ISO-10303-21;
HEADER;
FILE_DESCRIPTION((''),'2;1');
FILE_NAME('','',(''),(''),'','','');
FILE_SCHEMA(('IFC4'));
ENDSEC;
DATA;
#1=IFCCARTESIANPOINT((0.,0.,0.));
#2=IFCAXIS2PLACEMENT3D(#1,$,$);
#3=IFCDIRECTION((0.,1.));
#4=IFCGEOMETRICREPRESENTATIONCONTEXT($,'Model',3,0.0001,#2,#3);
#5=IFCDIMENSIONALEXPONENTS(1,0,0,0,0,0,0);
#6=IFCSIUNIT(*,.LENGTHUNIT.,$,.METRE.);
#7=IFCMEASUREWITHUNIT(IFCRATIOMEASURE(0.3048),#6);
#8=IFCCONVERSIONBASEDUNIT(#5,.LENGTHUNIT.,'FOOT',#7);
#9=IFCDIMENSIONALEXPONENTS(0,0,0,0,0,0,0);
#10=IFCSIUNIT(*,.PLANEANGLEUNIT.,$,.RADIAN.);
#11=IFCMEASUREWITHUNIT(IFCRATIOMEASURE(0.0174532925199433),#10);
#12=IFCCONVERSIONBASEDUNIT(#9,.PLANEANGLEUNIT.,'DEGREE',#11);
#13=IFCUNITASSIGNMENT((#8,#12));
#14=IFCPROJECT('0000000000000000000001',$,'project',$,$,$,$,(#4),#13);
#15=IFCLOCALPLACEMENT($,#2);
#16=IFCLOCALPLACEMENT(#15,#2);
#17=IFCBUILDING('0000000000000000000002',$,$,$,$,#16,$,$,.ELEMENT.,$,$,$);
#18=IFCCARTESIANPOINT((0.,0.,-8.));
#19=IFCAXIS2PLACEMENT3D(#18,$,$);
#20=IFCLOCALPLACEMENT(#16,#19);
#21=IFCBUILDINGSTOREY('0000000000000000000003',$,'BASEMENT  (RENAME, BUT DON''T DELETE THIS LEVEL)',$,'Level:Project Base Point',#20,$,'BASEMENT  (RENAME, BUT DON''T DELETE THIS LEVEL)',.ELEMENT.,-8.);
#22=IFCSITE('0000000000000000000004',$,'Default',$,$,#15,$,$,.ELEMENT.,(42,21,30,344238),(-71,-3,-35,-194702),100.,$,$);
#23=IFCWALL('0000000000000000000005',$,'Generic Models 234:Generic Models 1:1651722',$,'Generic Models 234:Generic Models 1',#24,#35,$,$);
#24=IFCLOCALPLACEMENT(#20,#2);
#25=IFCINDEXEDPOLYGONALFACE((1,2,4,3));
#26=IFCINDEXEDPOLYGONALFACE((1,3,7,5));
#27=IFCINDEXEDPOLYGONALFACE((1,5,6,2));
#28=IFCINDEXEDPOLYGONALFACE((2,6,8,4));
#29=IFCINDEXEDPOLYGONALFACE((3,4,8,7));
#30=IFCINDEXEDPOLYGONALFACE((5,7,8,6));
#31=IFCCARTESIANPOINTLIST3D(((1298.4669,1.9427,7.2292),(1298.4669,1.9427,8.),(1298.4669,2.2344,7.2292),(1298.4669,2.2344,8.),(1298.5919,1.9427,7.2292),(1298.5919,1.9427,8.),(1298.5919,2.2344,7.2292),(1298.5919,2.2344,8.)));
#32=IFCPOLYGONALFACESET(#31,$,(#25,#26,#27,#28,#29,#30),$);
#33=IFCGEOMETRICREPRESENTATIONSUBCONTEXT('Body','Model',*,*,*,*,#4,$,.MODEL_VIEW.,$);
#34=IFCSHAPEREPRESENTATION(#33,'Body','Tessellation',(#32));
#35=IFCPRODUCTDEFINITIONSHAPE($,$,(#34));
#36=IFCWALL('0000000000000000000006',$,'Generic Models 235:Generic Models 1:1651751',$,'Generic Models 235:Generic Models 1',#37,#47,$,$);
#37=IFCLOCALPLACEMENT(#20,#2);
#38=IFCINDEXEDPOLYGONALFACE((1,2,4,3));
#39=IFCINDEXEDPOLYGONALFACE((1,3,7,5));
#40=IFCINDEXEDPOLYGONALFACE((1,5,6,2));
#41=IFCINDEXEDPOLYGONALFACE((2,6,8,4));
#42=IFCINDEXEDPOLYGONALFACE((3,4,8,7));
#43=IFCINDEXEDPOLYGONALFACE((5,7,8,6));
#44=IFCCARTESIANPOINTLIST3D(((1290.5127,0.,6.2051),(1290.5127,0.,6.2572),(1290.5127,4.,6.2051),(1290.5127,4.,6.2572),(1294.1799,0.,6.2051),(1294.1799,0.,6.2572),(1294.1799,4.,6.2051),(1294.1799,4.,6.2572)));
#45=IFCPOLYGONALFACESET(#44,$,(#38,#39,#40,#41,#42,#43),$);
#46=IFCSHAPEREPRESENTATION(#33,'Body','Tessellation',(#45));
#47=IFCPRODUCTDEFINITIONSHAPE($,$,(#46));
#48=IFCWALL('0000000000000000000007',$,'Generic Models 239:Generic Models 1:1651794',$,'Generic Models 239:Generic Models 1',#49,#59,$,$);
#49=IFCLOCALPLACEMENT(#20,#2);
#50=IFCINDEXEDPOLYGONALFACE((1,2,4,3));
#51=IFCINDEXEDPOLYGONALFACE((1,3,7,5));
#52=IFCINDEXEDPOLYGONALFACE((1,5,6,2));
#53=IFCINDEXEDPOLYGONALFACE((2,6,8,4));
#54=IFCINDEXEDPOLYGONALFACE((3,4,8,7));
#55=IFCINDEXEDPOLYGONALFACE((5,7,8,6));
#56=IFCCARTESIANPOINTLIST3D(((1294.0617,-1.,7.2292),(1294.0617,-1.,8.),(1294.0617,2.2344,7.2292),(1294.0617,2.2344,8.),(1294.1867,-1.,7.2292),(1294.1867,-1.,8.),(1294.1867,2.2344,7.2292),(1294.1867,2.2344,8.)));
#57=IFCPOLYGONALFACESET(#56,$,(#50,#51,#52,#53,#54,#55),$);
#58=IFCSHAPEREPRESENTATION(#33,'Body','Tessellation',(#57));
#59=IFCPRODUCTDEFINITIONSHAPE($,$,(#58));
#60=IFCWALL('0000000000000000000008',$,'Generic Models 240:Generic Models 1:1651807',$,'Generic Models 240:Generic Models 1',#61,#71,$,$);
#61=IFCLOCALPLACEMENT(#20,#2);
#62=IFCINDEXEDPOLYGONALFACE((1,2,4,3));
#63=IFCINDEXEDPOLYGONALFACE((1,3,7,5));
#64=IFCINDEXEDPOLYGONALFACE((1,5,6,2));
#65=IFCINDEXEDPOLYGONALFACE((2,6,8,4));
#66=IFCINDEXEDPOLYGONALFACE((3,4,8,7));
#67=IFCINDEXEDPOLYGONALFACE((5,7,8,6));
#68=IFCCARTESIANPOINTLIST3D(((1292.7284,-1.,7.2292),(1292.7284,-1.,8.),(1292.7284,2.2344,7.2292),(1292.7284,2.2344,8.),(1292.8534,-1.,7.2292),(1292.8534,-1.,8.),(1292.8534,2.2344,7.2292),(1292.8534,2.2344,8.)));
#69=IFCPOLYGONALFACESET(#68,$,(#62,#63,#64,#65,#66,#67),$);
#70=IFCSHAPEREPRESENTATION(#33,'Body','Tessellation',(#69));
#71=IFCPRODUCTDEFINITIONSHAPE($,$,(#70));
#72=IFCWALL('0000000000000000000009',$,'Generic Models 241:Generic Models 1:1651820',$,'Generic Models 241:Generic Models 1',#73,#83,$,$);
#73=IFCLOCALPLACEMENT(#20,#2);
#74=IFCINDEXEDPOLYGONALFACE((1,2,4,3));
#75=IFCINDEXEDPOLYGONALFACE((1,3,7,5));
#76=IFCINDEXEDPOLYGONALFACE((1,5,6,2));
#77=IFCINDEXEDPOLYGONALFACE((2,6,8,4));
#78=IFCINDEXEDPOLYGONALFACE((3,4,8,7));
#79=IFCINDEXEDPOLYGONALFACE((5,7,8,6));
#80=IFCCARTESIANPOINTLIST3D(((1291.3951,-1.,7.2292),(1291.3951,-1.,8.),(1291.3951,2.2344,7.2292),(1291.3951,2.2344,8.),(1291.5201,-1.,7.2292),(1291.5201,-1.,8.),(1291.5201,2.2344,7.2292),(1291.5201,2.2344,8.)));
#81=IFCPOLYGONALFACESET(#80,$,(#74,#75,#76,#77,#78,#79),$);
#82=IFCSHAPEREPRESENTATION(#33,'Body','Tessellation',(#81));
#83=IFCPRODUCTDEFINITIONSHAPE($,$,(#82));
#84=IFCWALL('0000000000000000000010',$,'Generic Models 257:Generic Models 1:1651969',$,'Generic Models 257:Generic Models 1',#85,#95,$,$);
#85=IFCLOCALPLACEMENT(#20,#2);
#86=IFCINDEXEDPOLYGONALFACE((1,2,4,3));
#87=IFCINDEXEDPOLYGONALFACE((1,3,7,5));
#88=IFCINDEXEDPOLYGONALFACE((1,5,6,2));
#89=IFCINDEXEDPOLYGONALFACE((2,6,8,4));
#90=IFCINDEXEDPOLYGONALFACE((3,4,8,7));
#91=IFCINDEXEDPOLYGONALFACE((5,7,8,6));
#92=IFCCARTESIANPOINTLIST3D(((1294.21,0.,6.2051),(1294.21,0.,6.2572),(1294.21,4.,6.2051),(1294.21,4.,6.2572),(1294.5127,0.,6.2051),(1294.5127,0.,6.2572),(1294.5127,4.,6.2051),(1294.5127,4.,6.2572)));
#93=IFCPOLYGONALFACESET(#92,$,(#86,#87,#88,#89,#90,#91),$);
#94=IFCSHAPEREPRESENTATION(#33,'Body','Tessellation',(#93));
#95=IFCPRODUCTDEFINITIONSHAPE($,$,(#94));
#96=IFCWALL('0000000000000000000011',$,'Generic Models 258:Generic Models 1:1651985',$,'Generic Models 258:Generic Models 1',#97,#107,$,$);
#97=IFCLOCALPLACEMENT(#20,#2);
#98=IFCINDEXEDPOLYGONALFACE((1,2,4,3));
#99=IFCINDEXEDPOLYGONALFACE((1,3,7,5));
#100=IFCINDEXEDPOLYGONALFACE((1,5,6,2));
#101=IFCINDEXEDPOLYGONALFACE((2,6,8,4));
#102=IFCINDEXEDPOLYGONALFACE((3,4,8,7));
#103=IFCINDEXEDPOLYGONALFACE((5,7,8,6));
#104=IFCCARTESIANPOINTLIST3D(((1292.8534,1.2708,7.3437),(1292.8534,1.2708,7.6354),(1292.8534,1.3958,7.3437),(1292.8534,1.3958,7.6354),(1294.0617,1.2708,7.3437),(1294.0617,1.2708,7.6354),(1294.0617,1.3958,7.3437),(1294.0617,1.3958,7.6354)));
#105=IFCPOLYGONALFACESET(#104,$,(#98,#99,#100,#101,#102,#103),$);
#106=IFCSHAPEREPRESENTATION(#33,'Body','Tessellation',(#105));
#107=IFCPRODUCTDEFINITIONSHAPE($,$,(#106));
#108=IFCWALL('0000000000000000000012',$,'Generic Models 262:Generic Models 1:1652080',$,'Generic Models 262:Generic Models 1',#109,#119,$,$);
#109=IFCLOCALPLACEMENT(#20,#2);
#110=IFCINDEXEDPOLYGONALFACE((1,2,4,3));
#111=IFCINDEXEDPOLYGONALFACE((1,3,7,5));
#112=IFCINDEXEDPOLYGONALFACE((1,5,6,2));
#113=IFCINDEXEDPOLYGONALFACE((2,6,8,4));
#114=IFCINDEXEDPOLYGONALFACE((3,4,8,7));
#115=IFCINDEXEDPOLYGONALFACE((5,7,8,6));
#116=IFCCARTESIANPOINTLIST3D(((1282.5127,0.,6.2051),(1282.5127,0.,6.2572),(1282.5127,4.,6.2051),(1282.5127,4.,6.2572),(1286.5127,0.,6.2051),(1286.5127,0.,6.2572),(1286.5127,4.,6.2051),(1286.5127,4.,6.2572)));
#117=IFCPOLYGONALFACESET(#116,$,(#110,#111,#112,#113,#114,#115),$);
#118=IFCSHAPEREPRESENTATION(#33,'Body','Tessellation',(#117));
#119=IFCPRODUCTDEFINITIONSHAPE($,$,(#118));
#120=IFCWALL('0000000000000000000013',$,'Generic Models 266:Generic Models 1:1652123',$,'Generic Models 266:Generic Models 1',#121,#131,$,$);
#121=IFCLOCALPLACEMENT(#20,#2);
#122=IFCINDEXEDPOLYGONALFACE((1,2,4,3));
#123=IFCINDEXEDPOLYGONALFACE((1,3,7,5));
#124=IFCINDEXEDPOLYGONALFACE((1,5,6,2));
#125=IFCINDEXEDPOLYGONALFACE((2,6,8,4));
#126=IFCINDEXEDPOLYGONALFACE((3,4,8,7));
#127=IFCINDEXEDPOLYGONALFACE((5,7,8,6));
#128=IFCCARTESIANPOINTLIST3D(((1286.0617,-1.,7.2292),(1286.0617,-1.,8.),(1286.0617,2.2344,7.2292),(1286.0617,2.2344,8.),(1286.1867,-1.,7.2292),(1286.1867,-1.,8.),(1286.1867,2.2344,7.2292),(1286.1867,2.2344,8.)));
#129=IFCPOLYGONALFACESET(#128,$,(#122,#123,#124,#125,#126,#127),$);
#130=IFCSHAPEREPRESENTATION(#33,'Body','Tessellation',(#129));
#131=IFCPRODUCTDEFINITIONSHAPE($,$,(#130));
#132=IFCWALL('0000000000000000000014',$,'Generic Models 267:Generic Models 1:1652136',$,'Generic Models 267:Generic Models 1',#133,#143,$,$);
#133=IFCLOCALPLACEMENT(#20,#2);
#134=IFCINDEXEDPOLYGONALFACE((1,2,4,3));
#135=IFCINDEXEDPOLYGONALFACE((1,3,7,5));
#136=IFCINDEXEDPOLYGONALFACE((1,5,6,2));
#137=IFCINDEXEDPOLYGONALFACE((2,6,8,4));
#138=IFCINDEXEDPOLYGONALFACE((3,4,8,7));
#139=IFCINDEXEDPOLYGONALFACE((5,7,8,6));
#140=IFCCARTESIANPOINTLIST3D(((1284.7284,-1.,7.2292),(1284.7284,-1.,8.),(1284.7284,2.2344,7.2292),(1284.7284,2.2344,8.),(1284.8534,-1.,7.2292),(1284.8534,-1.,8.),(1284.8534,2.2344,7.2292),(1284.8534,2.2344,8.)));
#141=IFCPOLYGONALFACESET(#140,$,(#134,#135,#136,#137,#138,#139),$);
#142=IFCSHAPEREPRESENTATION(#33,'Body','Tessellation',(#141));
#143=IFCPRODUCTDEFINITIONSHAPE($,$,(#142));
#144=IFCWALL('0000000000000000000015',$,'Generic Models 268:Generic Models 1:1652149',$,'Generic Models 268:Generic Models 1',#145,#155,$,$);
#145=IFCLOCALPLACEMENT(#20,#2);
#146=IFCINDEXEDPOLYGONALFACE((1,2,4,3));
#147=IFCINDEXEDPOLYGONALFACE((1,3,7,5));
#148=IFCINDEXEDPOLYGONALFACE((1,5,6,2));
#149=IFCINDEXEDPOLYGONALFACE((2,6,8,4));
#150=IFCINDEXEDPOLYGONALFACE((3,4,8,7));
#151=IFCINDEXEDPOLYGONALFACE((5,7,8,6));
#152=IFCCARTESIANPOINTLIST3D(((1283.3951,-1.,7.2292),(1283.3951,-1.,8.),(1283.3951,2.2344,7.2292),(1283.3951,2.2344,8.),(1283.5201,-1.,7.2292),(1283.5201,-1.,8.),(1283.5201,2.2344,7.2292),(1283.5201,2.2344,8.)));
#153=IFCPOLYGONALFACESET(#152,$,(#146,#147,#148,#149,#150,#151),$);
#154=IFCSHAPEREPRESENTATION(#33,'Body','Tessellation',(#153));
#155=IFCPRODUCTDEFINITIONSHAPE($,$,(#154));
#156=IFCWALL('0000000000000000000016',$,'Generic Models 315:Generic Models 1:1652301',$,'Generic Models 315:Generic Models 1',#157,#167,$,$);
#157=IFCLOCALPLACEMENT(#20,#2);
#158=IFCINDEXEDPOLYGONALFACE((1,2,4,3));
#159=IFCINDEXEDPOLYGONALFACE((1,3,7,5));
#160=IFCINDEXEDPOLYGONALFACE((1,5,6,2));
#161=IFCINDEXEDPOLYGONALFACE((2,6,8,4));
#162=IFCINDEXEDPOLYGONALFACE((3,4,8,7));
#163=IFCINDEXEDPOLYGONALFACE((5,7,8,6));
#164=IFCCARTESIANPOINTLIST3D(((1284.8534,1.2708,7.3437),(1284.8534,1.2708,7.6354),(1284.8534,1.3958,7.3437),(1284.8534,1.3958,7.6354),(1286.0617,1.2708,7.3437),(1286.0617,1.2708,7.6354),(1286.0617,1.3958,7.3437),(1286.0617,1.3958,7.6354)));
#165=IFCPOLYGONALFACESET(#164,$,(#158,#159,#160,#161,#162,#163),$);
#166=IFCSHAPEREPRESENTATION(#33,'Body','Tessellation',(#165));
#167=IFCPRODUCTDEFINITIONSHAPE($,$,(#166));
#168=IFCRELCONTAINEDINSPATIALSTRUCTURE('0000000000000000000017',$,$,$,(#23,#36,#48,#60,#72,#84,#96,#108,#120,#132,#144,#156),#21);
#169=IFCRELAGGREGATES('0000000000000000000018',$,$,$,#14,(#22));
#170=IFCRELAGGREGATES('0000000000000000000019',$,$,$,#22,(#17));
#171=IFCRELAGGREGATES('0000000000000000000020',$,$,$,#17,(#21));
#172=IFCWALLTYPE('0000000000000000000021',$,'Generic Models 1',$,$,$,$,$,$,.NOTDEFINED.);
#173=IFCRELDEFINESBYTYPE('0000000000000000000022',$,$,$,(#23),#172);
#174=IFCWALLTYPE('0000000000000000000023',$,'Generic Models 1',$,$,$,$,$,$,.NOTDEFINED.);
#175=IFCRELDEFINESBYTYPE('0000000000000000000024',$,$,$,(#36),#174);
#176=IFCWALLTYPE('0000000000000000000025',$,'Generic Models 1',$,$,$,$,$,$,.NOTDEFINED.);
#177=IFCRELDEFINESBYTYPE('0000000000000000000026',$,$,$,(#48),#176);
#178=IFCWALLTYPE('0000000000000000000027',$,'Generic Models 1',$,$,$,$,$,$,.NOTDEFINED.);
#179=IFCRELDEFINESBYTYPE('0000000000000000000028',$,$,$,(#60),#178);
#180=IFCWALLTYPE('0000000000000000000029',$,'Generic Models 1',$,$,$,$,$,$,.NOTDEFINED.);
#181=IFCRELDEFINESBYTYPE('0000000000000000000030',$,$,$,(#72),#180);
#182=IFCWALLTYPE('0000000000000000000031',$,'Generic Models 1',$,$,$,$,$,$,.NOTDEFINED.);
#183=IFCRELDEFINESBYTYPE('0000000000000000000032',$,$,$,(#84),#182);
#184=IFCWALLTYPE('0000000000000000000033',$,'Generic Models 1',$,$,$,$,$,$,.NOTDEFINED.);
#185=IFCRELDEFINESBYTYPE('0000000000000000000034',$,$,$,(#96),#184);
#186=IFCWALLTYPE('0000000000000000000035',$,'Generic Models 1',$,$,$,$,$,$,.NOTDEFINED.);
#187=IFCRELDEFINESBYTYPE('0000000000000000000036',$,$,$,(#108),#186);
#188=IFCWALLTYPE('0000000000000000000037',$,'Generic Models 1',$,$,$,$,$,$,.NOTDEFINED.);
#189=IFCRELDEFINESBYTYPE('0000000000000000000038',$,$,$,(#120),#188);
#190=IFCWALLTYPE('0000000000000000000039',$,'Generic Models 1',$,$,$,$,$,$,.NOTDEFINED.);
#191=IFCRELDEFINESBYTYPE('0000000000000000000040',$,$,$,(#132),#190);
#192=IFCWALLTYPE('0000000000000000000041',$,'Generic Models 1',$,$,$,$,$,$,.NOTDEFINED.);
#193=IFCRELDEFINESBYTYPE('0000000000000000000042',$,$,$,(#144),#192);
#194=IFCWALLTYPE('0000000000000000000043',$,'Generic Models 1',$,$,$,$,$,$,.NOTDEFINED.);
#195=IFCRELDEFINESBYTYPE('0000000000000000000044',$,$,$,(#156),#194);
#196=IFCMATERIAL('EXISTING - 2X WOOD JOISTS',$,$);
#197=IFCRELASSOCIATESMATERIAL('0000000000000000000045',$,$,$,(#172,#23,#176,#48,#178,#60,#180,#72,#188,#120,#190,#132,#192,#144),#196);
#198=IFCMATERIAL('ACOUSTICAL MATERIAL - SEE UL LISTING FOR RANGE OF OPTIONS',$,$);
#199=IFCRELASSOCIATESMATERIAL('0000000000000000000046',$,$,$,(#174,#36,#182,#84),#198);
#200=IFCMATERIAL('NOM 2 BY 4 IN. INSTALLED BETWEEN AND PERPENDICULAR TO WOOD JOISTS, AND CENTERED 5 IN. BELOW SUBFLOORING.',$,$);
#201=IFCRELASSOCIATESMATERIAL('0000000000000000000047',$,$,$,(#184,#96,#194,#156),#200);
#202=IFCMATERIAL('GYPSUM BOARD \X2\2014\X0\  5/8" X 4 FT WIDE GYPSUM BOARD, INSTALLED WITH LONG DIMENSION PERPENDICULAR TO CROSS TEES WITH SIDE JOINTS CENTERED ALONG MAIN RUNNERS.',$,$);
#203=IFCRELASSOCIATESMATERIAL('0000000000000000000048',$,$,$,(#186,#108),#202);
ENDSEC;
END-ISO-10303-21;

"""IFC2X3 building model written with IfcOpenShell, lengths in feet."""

from ifc_helpers import new_model, entity, si_unit, converted_unit, direction, frame, frame_2d, origin, origin_2d_with_axis, place, context, subcontext, project, spatial, rectangle, extrude, material, type_object, element, save


model = new_model("IFC2X3")

# Units and contexts
model_context = context("Model", 3, precision=0.0001, world=origin(), true_north=direction((0.0, 1.0)))
body_context = subcontext(model_context, "Body", "Model", "MODEL_VIEW")
ifc_project = project(units=[converted_unit("LENGTHUNIT", "FOOT", entity("IfcRatioMeasure", 0.3048), si_unit("LENGTHUNIT", "METRE"), dimensions=[1, 0, 0, 0, 0, 0, 0]), converted_unit("PLANEANGLEUNIT", "DEGREE", entity("IfcRatioMeasure", 0.0174532925199433), si_unit("PLANEANGLEUNIT", "RADIAN"), dimensions=[0, 0, 0, 0, 0, 0, 0])], contexts=[model_context])

# Site, building, storey
site_placement = place(None, origin())
site = spatial("IfcSite", under=ifc_project, at=site_placement, Name="Default", CompositionType="ELEMENT", RefLatitude=(42, 21, 30, 344238), RefLongitude=(-71, -3, -35, -194702), RefElevation=100.0)
building_placement = place(site_placement, origin())
building = spatial("IfcBuilding", under=site, at=building_placement, CompositionType="ELEMENT")
storey_placement = place(building_placement, frame((0.0, 0.0, -8.0)))
storey = spatial("IfcBuildingStorey", under=building, at=storey_placement, Name="BASEMENT  (RENAME, BUT DON'T DELETE THIS LEVEL)", ObjectType="Level:Project Base Point", LongName="BASEMENT  (RENAME, BUT DON'T DELETE THIS LEVEL)", CompositionType="ELEMENT", Elevation=-8.0)

# Walls
ifc_material_1 = material(Name="EXISTING - 2X WOOD JOISTS")
wall_type_1 = type_object("IfcWallType", Name="Generic Models 1", PredefinedType="NOTDEFINED", material=ifc_material_1)
wall_1_placement = place(storey_placement, frame((1298.4669, 1.9427, 7.2292), z_axis=(0.0, 0.0, 1.0), x_axis=(0.0, 1.0, 0.0)))
element("IfcWall", 1, at=wall_1_placement, inside=storey, type_object=wall_type_1, material=ifc_material_1, Name="Generic Models 234:Generic Models 1:1651722", ObjectType="Generic Models 234:Generic Models 1", context=body_context, shape_type="SweptSolid", body=[
    extrude(rectangle(XDim=0.2917, YDim=0.125, at=frame_2d((0.0, 0.0), x_axis=(1.0, 0.0))), frame((0.1458, -0.0625, 0.0)), (0.0, 0.0, 1.0), 0.7708),
])
ifc_material_2 = material(Name="ACOUSTICAL MATERIAL - SEE UL LISTING FOR RANGE OF OPTIONS")
wall_type_2 = type_object("IfcWallType", Name="Generic Models 1", PredefinedType="NOTDEFINED", material=ifc_material_2)
wall_2_placement = place(storey_placement, frame((1290.5127, 0.0, 6.2051), z_axis=(0.0, 0.0, 1.0), x_axis=(0.0, 1.0, 0.0)))
element("IfcWall", 2, at=wall_2_placement, inside=storey, type_object=wall_type_2, material=ifc_material_2, Name="Generic Models 235:Generic Models 1:1651751", ObjectType="Generic Models 235:Generic Models 1", context=body_context, shape_type="SweptSolid", body=[
    extrude(rectangle(XDim=4.0, YDim=3.6671, at=frame_2d((0.0, 0.0), x_axis=(1.0, 0.0))), frame((2.0, -1.8336, 0.0)), (0.0, 0.0, 1.0), 0.0521),
])
wall_type_3 = type_object("IfcWallType", Name="Generic Models 1", PredefinedType="NOTDEFINED", material=ifc_material_1)
wall_3_placement = place(storey_placement, frame((1294.0617, -1.0, 7.2292), z_axis=(0.0, 0.0, 1.0), x_axis=(0.0, 1.0, 0.0)))
element("IfcWall", 3, at=wall_3_placement, inside=storey, type_object=wall_type_3, material=ifc_material_1, Name="Generic Models 239:Generic Models 1:1651794", ObjectType="Generic Models 239:Generic Models 1", context=body_context, shape_type="SweptSolid", body=[
    extrude(rectangle(XDim=3.2344, YDim=0.125, at=frame_2d((0.0, 0.0), x_axis=(1.0, 0.0))), frame((1.6172, -0.0625, 0.0)), (0.0, 0.0, 1.0), 0.7708),
])
wall_type_4 = type_object("IfcWallType", Name="Generic Models 1", PredefinedType="NOTDEFINED", material=ifc_material_1)
wall_4_placement = place(storey_placement, frame((1292.7284, -1.0, 7.2292), z_axis=(0.0, 0.0, 1.0), x_axis=(0.0, 1.0, 0.0)))
element("IfcWall", 4, at=wall_4_placement, inside=storey, type_object=wall_type_4, material=ifc_material_1, Name="Generic Models 240:Generic Models 1:1651807", ObjectType="Generic Models 240:Generic Models 1", context=body_context, shape_type="SweptSolid", body=[
    extrude(rectangle(XDim=3.2344, YDim=0.125, at=frame_2d((0.0, 0.0), x_axis=(1.0, 0.0))), frame((1.6172, -0.0625, 0.0)), (0.0, 0.0, 1.0), 0.7708),
])
wall_type_5 = type_object("IfcWallType", Name="Generic Models 1", PredefinedType="NOTDEFINED", material=ifc_material_1)
wall_5_placement = place(storey_placement, frame((1291.3951, -1.0, 7.2292), z_axis=(0.0, 0.0, 1.0), x_axis=(0.0, 1.0, 0.0)))
element("IfcWall", 5, at=wall_5_placement, inside=storey, type_object=wall_type_5, material=ifc_material_1, Name="Generic Models 241:Generic Models 1:1651820", ObjectType="Generic Models 241:Generic Models 1", context=body_context, shape_type="SweptSolid", body=[
    extrude(rectangle(XDim=3.2344, YDim=0.125, at=frame_2d((0.0, 0.0), x_axis=(1.0, 0.0))), frame((1.6172, -0.0625, 0.0)), (0.0, 0.0, 1.0), 0.7708),
])
wall_type_6 = type_object("IfcWallType", Name="Generic Models 1", PredefinedType="NOTDEFINED", material=ifc_material_2)
wall_6_placement = place(storey_placement, frame((1294.21, 0.0, 6.2051), z_axis=(0.0, 0.0, 1.0), x_axis=(0.0, 1.0, 0.0)))
element("IfcWall", 6, at=wall_6_placement, inside=storey, type_object=wall_type_6, material=ifc_material_2, Name="Generic Models 257:Generic Models 1:1651969", ObjectType="Generic Models 257:Generic Models 1", context=body_context, shape_type="SweptSolid", body=[
    extrude(rectangle(XDim=4.0, YDim=0.3027, at=frame_2d((0.0, 0.0), x_axis=(1.0, 0.0))), frame((2.0, -0.1514, 0.0)), (0.0, 0.0, 1.0), 0.0521),
])
ifc_material_3 = material(Name="NOM 2 BY 4 IN. INSTALLED BETWEEN AND PERPENDICULAR TO WOOD JOISTS, AND CENTERED 5 IN. BELOW SUBFLOORING.")
wall_type_7 = type_object("IfcWallType", Name="Generic Models 1", PredefinedType="NOTDEFINED", material=ifc_material_3)
wall_7_placement = place(storey_placement, frame((1292.8534, 1.2708, 7.3437)))
element("IfcWall", 7, at=wall_7_placement, inside=storey, type_object=wall_type_7, material=ifc_material_3, Name="Generic Models 258:Generic Models 1:1651985", ObjectType="Generic Models 258:Generic Models 1", context=body_context, shape_type="SweptSolid", body=[
    extrude(rectangle(XDim=0.125, YDim=1.2083, at=frame_2d((0.0, 0.0), x_axis=(1.0, 0.0))), frame((0.6042, 0.0625, 0.0), z_axis=(0.0, 0.0, 1.0), x_axis=(0.0, 1.0, 0.0)), (0.0, 0.0, 1.0), 0.2917),
])
ifc_material_4 = material(Name="GYPSUM BOARD —  5/8\" X 4 FT WIDE GYPSUM BOARD, INSTALLED WITH LONG DIMENSION PERPENDICULAR TO CROSS TEES WITH SIDE JOINTS CENTERED ALONG MAIN RUNNERS.")
wall_type_8 = type_object("IfcWallType", Name="Generic Models 1", PredefinedType="NOTDEFINED", material=ifc_material_4)
wall_8_placement = place(storey_placement, frame((1282.5127, 0.0, 6.2051), z_axis=(0.0, 0.0, 1.0), x_axis=(0.0, 1.0, 0.0)))
element("IfcWall", 8, at=wall_8_placement, inside=storey, type_object=wall_type_8, material=ifc_material_4, Name="Generic Models 262:Generic Models 1:1652080", ObjectType="Generic Models 262:Generic Models 1", context=body_context, shape_type="SweptSolid", body=[
    extrude(rectangle(XDim=4.0, YDim=4.0, at=origin_2d_with_axis()), frame((2.0, -2.0, 0.0)), (0.0, 0.0, 1.0), 0.0521),
])
wall_type_9 = type_object("IfcWallType", Name="Generic Models 1", PredefinedType="NOTDEFINED", material=ifc_material_1)
wall_9_placement = place(storey_placement, frame((1286.0617, -1.0, 7.2292), z_axis=(0.0, 0.0, 1.0), x_axis=(0.0, 1.0, 0.0)))
element("IfcWall", 9, at=wall_9_placement, inside=storey, type_object=wall_type_9, material=ifc_material_1, Name="Generic Models 266:Generic Models 1:1652123", ObjectType="Generic Models 266:Generic Models 1", context=body_context, shape_type="SweptSolid", body=[
    extrude(rectangle(XDim=3.2344, YDim=0.125, at=frame_2d((0.0, 0.0), x_axis=(1.0, 0.0))), frame((1.6172, -0.0625, 0.0)), (0.0, 0.0, 1.0), 0.7708),
])
wall_type_10 = type_object("IfcWallType", Name="Generic Models 1", PredefinedType="NOTDEFINED", material=ifc_material_1)
wall_10_placement = place(storey_placement, frame((1284.7284, -1.0, 7.2292), z_axis=(0.0, 0.0, 1.0), x_axis=(0.0, 1.0, 0.0)))
element("IfcWall", 10, at=wall_10_placement, inside=storey, type_object=wall_type_10, material=ifc_material_1, Name="Generic Models 267:Generic Models 1:1652136", ObjectType="Generic Models 267:Generic Models 1", context=body_context, shape_type="SweptSolid", body=[
    extrude(rectangle(XDim=3.2344, YDim=0.125, at=frame_2d((0.0, 0.0), x_axis=(1.0, 0.0))), frame((1.6172, -0.0625, 0.0)), (0.0, 0.0, 1.0), 0.7708),
])
wall_type_11 = type_object("IfcWallType", Name="Generic Models 1", PredefinedType="NOTDEFINED", material=ifc_material_1)
wall_11_placement = place(storey_placement, frame((1283.3951, -1.0, 7.2292), z_axis=(0.0, 0.0, 1.0), x_axis=(0.0, 1.0, 0.0)))
element("IfcWall", 11, at=wall_11_placement, inside=storey, type_object=wall_type_11, material=ifc_material_1, Name="Generic Models 268:Generic Models 1:1652149", ObjectType="Generic Models 268:Generic Models 1", context=body_context, shape_type="SweptSolid", body=[
    extrude(rectangle(XDim=3.2344, YDim=0.125, at=frame_2d((0.0, 0.0), x_axis=(1.0, 0.0))), frame((1.6172, -0.0625, 0.0)), (0.0, 0.0, 1.0), 0.7708),
])
wall_type_12 = type_object("IfcWallType", Name="Generic Models 1", PredefinedType="NOTDEFINED", material=ifc_material_3)
wall_12_placement = place(storey_placement, frame((1284.8534, 1.2708, 7.3437)))
element("IfcWall", 12, at=wall_12_placement, inside=storey, type_object=wall_type_12, material=ifc_material_3, Name="Generic Models 315:Generic Models 1:1652301", ObjectType="Generic Models 315:Generic Models 1", context=body_context, shape_type="SweptSolid", body=[
    extrude(rectangle(XDim=0.125, YDim=1.2083, at=frame_2d((0.0, 0.0), x_axis=(1.0, 0.0))), frame((0.6042, 0.0625, 0.0), z_axis=(0.0, 0.0, 1.0), x_axis=(0.0, 1.0, 0.0)), (0.0, 0.0, 1.0), 0.2917),
])

save(model, "model.ifc")
